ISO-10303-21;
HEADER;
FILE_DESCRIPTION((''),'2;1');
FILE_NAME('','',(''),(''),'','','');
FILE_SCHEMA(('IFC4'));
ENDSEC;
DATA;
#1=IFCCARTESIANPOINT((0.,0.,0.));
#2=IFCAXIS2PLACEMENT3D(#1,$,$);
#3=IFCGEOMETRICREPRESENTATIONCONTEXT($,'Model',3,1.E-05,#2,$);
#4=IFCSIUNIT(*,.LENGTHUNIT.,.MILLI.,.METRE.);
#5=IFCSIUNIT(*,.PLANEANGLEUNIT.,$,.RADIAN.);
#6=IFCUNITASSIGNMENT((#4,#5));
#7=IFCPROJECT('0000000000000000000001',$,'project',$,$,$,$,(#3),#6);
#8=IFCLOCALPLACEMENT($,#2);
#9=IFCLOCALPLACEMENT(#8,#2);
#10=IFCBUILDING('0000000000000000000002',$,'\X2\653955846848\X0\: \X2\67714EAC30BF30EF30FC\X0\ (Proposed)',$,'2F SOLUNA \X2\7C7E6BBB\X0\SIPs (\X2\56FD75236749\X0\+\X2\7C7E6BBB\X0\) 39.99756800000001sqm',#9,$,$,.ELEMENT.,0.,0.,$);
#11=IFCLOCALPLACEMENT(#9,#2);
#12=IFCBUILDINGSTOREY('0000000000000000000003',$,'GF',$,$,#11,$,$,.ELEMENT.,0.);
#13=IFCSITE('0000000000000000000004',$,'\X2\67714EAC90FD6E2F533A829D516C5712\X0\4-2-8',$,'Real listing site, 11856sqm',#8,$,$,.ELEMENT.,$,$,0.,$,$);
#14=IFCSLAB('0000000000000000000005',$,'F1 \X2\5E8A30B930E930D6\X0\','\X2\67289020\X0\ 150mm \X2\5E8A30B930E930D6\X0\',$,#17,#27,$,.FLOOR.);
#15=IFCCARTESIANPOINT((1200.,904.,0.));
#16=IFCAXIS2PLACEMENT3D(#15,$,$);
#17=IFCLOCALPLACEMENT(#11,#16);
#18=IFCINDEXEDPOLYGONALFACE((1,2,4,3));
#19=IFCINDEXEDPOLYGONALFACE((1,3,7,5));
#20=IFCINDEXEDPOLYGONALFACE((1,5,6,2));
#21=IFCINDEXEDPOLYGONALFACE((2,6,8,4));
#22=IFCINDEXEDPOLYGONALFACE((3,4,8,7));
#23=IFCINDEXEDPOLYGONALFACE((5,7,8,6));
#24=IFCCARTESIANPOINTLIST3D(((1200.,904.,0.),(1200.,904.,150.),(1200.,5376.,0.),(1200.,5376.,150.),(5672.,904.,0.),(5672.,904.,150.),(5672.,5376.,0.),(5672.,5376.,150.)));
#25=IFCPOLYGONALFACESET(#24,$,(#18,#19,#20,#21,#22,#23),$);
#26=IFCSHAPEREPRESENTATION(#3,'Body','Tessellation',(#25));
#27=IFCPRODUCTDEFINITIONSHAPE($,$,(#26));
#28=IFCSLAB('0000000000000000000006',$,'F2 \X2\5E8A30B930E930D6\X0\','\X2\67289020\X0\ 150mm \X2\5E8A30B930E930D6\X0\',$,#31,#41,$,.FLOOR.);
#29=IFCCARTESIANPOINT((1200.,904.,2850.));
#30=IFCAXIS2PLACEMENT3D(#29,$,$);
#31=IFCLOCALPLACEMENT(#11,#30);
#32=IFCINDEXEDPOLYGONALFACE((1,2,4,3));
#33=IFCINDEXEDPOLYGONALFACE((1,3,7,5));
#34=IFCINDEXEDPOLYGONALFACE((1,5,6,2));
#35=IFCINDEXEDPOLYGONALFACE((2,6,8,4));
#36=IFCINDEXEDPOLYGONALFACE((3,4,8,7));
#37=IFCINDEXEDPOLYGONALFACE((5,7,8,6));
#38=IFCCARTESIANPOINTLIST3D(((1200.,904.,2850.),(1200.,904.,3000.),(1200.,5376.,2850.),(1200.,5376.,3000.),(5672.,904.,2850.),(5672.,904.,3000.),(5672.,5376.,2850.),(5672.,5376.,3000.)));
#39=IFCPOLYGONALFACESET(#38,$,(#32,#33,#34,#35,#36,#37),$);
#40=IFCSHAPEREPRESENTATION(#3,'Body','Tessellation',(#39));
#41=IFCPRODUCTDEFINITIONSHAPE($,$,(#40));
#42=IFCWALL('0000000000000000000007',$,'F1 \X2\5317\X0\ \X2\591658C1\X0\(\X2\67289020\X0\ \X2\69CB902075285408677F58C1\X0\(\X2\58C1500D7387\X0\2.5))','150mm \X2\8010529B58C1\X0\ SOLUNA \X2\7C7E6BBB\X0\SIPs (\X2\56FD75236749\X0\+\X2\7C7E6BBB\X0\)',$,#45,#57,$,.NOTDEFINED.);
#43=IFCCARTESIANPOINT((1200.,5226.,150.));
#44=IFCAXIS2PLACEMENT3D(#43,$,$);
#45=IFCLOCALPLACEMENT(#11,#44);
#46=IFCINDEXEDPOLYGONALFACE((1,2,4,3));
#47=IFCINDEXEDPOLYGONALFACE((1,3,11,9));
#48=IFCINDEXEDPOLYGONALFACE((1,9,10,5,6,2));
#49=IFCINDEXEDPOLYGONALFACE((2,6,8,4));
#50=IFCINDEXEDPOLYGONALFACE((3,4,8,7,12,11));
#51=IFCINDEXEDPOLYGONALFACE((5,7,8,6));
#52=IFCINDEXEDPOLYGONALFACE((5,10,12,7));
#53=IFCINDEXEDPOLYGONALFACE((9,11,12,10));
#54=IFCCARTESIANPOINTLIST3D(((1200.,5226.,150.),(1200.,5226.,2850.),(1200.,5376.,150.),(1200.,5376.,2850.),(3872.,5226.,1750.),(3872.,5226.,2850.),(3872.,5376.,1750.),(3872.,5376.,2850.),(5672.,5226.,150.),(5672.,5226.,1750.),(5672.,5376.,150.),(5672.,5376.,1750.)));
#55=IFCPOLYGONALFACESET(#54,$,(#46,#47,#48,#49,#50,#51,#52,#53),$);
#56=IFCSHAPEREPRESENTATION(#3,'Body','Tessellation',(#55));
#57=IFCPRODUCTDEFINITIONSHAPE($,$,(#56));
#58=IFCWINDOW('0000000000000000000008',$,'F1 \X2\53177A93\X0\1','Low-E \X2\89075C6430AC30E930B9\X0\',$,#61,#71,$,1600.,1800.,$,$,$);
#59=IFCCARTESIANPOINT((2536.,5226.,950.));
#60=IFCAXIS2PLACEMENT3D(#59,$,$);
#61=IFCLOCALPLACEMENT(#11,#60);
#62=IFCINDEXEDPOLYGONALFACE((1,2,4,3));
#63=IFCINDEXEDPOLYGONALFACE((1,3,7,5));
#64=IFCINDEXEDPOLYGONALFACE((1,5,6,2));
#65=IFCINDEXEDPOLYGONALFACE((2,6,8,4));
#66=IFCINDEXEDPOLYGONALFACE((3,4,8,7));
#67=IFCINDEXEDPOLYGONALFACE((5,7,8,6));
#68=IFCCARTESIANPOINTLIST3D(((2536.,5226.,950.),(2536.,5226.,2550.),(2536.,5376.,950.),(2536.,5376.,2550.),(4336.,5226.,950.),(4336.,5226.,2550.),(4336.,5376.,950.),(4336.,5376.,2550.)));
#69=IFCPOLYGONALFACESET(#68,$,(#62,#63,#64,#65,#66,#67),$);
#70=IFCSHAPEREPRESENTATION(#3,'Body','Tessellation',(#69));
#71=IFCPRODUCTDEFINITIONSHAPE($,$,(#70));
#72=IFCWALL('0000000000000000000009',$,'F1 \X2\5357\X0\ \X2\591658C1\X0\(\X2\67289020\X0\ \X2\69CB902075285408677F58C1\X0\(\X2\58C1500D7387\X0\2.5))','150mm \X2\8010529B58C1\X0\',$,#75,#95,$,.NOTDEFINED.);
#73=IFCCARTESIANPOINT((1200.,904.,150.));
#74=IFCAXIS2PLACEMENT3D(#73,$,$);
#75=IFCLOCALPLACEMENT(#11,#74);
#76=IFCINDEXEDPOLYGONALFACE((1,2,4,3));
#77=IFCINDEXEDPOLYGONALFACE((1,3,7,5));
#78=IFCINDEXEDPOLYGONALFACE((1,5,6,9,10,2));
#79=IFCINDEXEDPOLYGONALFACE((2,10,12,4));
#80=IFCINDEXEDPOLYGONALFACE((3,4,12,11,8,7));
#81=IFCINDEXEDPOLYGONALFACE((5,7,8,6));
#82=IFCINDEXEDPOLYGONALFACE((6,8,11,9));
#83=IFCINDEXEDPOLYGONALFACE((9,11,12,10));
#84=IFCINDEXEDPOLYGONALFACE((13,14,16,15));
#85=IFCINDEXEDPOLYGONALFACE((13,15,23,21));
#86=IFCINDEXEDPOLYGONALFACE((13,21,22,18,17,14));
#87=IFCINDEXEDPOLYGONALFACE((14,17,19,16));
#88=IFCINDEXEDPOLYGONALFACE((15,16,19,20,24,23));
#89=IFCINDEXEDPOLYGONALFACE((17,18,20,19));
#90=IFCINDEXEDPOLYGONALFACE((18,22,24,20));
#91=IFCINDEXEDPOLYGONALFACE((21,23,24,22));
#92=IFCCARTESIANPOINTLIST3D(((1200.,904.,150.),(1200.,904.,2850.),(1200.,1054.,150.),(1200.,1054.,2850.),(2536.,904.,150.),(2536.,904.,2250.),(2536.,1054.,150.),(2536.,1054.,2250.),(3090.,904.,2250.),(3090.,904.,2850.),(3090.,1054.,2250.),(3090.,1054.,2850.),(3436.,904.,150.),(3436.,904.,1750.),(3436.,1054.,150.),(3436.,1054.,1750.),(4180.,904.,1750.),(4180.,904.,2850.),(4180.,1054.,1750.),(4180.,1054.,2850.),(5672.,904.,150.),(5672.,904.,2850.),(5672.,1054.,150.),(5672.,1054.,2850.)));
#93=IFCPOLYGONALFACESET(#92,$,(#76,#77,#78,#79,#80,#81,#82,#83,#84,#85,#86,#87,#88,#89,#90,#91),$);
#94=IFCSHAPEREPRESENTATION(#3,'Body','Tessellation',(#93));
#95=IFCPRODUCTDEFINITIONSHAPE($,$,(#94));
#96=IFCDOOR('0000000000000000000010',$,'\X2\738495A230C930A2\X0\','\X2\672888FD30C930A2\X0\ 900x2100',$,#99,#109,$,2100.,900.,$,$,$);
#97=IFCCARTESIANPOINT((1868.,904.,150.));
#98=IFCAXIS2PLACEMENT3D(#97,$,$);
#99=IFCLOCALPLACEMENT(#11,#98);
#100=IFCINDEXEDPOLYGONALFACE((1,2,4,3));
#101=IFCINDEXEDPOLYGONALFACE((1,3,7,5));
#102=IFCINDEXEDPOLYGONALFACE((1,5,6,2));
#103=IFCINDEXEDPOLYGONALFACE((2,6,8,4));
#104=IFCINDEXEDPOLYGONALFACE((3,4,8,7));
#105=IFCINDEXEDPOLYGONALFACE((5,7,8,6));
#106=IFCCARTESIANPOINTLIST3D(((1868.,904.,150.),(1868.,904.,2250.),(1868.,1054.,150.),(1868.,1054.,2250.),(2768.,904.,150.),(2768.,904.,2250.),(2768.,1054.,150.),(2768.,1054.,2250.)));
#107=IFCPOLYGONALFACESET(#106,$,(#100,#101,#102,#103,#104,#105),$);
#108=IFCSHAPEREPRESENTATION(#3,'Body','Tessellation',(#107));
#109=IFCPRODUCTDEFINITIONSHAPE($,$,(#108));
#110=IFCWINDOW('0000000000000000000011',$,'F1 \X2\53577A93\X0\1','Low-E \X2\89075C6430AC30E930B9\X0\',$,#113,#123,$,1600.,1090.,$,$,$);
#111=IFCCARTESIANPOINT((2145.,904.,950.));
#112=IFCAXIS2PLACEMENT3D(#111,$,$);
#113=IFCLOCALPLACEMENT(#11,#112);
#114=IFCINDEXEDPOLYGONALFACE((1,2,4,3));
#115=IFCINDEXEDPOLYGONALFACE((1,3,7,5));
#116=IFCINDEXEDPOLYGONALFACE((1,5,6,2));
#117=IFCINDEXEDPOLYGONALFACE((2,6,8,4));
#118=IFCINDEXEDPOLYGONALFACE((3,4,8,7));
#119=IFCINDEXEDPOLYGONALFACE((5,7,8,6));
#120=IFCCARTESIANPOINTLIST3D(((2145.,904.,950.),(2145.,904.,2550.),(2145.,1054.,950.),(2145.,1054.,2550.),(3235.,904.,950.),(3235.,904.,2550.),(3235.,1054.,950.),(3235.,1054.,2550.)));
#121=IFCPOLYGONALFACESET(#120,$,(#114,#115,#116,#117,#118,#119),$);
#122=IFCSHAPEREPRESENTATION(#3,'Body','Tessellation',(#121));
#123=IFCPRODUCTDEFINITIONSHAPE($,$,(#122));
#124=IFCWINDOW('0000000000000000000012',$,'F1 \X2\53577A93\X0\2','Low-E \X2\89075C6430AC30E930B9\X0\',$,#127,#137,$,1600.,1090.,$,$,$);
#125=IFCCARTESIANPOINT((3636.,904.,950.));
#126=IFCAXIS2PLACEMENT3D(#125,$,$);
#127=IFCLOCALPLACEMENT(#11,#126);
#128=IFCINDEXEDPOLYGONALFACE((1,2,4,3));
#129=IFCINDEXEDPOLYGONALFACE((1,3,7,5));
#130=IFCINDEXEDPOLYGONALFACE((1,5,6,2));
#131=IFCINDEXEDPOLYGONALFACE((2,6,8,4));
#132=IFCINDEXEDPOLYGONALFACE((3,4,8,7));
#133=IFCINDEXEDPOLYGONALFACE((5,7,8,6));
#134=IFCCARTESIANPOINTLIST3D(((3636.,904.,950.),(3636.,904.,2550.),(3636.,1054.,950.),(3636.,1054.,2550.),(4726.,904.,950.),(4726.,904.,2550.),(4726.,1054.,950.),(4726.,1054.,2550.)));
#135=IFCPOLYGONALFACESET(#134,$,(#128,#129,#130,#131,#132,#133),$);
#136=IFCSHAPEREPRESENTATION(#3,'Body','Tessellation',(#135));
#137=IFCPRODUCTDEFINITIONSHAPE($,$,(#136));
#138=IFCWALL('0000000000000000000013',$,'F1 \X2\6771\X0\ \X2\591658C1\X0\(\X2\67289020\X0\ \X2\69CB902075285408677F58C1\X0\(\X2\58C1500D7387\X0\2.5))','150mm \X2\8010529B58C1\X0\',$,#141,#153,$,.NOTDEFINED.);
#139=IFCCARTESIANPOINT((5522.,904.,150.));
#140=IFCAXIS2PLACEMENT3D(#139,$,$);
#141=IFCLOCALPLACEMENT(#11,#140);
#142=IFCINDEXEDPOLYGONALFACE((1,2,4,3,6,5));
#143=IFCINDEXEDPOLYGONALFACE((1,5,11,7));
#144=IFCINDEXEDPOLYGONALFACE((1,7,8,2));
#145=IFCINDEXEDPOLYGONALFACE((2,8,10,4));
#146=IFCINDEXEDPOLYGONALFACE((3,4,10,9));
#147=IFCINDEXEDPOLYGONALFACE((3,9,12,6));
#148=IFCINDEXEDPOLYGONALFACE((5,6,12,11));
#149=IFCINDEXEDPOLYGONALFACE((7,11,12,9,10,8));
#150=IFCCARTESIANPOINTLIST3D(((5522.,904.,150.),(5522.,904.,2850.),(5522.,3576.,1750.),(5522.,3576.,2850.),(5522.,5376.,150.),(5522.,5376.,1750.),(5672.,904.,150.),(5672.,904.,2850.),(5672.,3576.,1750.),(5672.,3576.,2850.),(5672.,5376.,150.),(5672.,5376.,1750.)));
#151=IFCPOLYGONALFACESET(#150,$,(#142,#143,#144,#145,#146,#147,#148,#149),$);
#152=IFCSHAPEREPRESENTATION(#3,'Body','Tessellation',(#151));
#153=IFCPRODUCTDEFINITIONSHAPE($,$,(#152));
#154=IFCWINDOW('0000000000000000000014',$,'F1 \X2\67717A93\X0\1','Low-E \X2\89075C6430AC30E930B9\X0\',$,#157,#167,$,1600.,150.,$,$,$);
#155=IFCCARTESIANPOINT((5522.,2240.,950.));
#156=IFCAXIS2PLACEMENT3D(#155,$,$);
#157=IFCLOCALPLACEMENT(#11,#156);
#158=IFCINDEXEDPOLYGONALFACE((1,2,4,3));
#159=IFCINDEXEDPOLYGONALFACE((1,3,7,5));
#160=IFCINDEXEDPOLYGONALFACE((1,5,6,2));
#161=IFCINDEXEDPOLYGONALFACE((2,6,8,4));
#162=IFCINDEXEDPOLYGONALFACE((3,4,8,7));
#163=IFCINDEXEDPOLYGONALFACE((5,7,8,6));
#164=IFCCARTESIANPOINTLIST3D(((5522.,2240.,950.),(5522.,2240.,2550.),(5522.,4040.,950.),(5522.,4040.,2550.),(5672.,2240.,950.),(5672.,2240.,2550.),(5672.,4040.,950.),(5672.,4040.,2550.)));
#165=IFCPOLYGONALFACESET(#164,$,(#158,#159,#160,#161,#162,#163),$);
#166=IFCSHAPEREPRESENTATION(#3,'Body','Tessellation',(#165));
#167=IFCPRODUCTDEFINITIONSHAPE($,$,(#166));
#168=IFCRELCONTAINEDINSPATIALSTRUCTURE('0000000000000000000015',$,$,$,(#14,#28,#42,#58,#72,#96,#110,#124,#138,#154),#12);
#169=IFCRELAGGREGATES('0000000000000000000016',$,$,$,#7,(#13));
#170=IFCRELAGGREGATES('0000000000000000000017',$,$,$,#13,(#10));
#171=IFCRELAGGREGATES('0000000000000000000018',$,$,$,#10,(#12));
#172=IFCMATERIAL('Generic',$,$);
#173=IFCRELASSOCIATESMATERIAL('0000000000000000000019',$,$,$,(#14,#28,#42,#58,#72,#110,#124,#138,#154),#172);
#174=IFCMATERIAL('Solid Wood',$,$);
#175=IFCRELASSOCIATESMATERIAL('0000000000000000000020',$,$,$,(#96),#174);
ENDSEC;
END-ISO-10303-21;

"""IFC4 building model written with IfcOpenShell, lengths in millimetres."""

from ifc_helpers import new_model, si_unit, frame, frame_2d, origin, place, context, project, spatial, rectangle, extrude, material, element, fill, save


model = new_model("IFC4")

# Units and contexts
model_context = context("Model", 3, precision=1e-05, world=origin())
ifc_project = project(units=[si_unit("LENGTHUNIT", "METRE", prefix="MILLI"), si_unit("PLANEANGLEUNIT", "RADIAN")], contexts=[model_context])

# Site, building, storey
site_placement = place(None, origin())
site = spatial("IfcSite", under=ifc_project, at=site_placement, Name="東京都港区芝公園4-2-8", ObjectType="Real listing site, 11856sqm", CompositionType="ELEMENT", RefElevation=0.0)
building_placement = place(site_placement, origin())
building = spatial("IfcBuilding", under=site, at=building_placement, Name="改善案: 東京タワー (Proposed)", ObjectType="2F SOLUNA 籾殻SIPs (国産杉+籾殻) 39.99756800000001sqm", CompositionType="ELEMENT", ElevationOfRefHeight=0.0, ElevationOfTerrain=0.0)
storey_placement = place(building_placement, origin())
storey = spatial("IfcBuildingStorey", under=building, at=storey_placement, Name="GF", CompositionType="ELEMENT", Elevation=0.0)

# Slabs
ifc_material_1 = material(Name="Generic")
slab_1_placement = place(storey_placement, frame((1200.0, 904.0, 0.0)))
element("IfcSlab", 1, at=slab_1_placement, inside=storey, material=ifc_material_1, Name="F1 床スラブ", Description="木造 150mm 床スラブ", PredefinedType="FLOOR", context=model_context, shape_type="SweptSolid", body=[
    extrude(rectangle(XDim=4472.0, YDim=4472.0, at=frame_2d((2236.0, 2236.0))), frame((1200.0, 904.0, 0.0)), (0.0, 0.0, 1.0), 150.0),
])
slab_2_placement = place(storey_placement, frame((1200.0, 904.0, 2850.0)))
element("IfcSlab", 2, at=slab_2_placement, inside=storey, material=ifc_material_1, Name="F2 床スラブ", Description="木造 150mm 床スラブ", PredefinedType="FLOOR", context=model_context, shape_type="SweptSolid", body=[
    extrude(rectangle(XDim=4472.0, YDim=4472.0, at=frame_2d((2236.0, 2236.0))), frame((1200.0, 904.0, 2850.0)), (0.0, 0.0, 1.0), 150.0),
])

# Wall, opening, window
wall_1_placement = place(storey_placement, frame((1200.0, 5226.0, 150.0)))
wall_1 = element("IfcWall", 3, at=wall_1_placement, inside=storey, material=ifc_material_1, Name="F1 北 外壁(木造 構造用合板壁(壁倍率2.5))", Description="150mm 耐力壁 SOLUNA 籾殻SIPs (国産杉+籾殻)", PredefinedType="NOTDEFINED", context=model_context, shape_type="SweptSolid", body=[
    extrude(rectangle(XDim=4472.0, YDim=150.0, at=frame_2d((2236.0, 75.0))), frame((1200.0, 5226.0, 150.0)), (0.0, 0.0, 1.0), 2700.0),
])
opening_1_placement = place(storey_placement, frame((2536.0, 5226.0, 950.0)))
opening_1 = element("IfcOpeningElement", 4, at=opening_1_placement, cuts=wall_1, PredefinedType="NOTDEFINED", context=model_context, shape_type="SweptSolid", body=[
    extrude(rectangle(XDim=1800.0, YDim=150.0, at=frame_2d((900.0, 75.0))), frame((2536.0, 5226.0, 950.0)), (0.0, 0.0, 1.0), 1600.0),
])
window_1_placement = place(storey_placement, frame((2536.0, 5226.0, 950.0)))
window_1 = element("IfcWindow", 5, at=window_1_placement, inside=storey, material=ifc_material_1, Name="F1 北窓1", Description="Low-E 複層ガラス", OverallHeight=1600.0, OverallWidth=1800.0, context=model_context, shape_type="SweptSolid", body=[
    extrude(rectangle(XDim=1800.0, YDim=150.0, at=frame_2d((900.0, 75.0))), frame((2536.0, 5226.0, 950.0)), (0.0, 0.0, 1.0), 1600.0),
])
fill(opening_1, window_1)

# Wall, openings, door, windows
wall_2_placement = place(storey_placement, frame((1200.0, 904.0, 150.0)))
wall_2 = element("IfcWall", 6, at=wall_2_placement, inside=storey, material=ifc_material_1, Name="F1 南 外壁(木造 構造用合板壁(壁倍率2.5))", Description="150mm 耐力壁", PredefinedType="NOTDEFINED", context=model_context, shape_type="SweptSolid", body=[
    extrude(rectangle(XDim=4472.0, YDim=150.0, at=frame_2d((2236.0, 75.0))), frame((1200.0, 904.0, 150.0)), (0.0, 0.0, 1.0), 2700.0),
])
opening_2_placement = place(storey_placement, frame((1868.0, 904.0, 150.0)))
opening_2 = element("IfcOpeningElement", 7, at=opening_2_placement, cuts=wall_2, PredefinedType="NOTDEFINED", context=model_context, shape_type="SweptSolid", body=[
    extrude(rectangle(XDim=900.0, YDim=150.0, at=frame_2d((450.0, 75.0))), frame((1868.0, 904.0, 150.0)), (0.0, 0.0, 1.0), 2100.0),
])
opening_3_placement = place(storey_placement, frame((2145.0, 904.0, 950.0)))
opening_3 = element("IfcOpeningElement", 8, at=opening_3_placement, cuts=wall_2, PredefinedType="NOTDEFINED", context=model_context, shape_type="SweptSolid", body=[
    extrude(rectangle(XDim=1090.0, YDim=150.0, at=frame_2d((545.0, 75.0))), frame((2145.0, 904.0, 950.0)), (0.0, 0.0, 1.0), 1600.0),
])
opening_4_placement = place(storey_placement, frame((3636.0, 904.0, 950.0)))
opening_4 = element("IfcOpeningElement", 9, at=opening_4_placement, cuts=wall_2, PredefinedType="NOTDEFINED", context=model_context, shape_type="SweptSolid", body=[
    extrude(rectangle(XDim=1090.0, YDim=150.0, at=frame_2d((545.0, 75.0))), frame((3636.0, 904.0, 950.0)), (0.0, 0.0, 1.0), 1600.0),
])
ifc_material_2 = material(Name="Solid Wood")
door_placement = place(storey_placement, frame((1868.0, 904.0, 150.0)))
door = element("IfcDoor", 10, at=door_placement, inside=storey, material=ifc_material_2, Name="玄関ドア", Description="木製ドア 900x2100", OverallHeight=2100.0, OverallWidth=900.0, context=model_context, shape_type="SweptSolid", body=[
    extrude(rectangle(XDim=900.0, YDim=150.0, at=frame_2d((450.0, 75.0))), frame((1868.0, 904.0, 150.0)), (0.0, 0.0, 1.0), 2100.0),
])
fill(opening_2, door)
window_2_placement = place(storey_placement, frame((2145.0, 904.0, 950.0)))
window_2 = element("IfcWindow", 11, at=window_2_placement, inside=storey, material=ifc_material_1, Name="F1 南窓1", Description="Low-E 複層ガラス", OverallHeight=1600.0, OverallWidth=1090.0, context=model_context, shape_type="SweptSolid", body=[
    extrude(rectangle(XDim=1090.0, YDim=150.0, at=frame_2d((545.0, 75.0))), frame((2145.0, 904.0, 950.0)), (0.0, 0.0, 1.0), 1600.0),
])
fill(opening_3, window_2)
window_3_placement = place(storey_placement, frame((3636.0, 904.0, 950.0)))
window_3 = element("IfcWindow", 12, at=window_3_placement, inside=storey, material=ifc_material_1, Name="F1 南窓2", Description="Low-E 複層ガラス", OverallHeight=1600.0, OverallWidth=1090.0, context=model_context, shape_type="SweptSolid", body=[
    extrude(rectangle(XDim=1090.0, YDim=150.0, at=frame_2d((545.0, 75.0))), frame((3636.0, 904.0, 950.0)), (0.0, 0.0, 1.0), 1600.0),
])
fill(opening_4, window_3)

# Wall, opening, window
wall_3_placement = place(storey_placement, frame((5522.0, 904.0, 150.0)))
wall_3 = element("IfcWall", 13, at=wall_3_placement, inside=storey, material=ifc_material_1, Name="F1 東 外壁(木造 構造用合板壁(壁倍率2.5))", Description="150mm 耐力壁", PredefinedType="NOTDEFINED", context=model_context, shape_type="SweptSolid", body=[
    extrude(rectangle(XDim=150.0, YDim=4472.0, at=frame_2d((75.0, 2236.0))), frame((5522.0, 904.0, 150.0)), (0.0, 0.0, 1.0), 2700.0),
])
opening_5_placement = place(storey_placement, frame((5522.0, 2240.0, 950.0)))
opening_5 = element("IfcOpeningElement", 14, at=opening_5_placement, cuts=wall_3, PredefinedType="NOTDEFINED", context=model_context, shape_type="SweptSolid", body=[
    extrude(rectangle(XDim=150.0, YDim=1800.0, at=frame_2d((75.0, 900.0))), frame((5522.0, 2240.0, 950.0)), (0.0, 0.0, 1.0), 1600.0),
])
window_4_placement = place(storey_placement, frame((5522.0, 2240.0, 950.0)))
window_4 = element("IfcWindow", 15, at=window_4_placement, inside=storey, material=ifc_material_1, Name="F1 東窓1", Description="Low-E 複層ガラス", OverallHeight=1600.0, OverallWidth=150.0, context=model_context, shape_type="SweptSolid", body=[
    extrude(rectangle(XDim=150.0, YDim=1800.0, at=frame_2d((75.0, 900.0))), frame((5522.0, 2240.0, 950.0)), (0.0, 0.0, 1.0), 1600.0),
])
fill(opening_5, window_4)

save(model, "model.ifc")
